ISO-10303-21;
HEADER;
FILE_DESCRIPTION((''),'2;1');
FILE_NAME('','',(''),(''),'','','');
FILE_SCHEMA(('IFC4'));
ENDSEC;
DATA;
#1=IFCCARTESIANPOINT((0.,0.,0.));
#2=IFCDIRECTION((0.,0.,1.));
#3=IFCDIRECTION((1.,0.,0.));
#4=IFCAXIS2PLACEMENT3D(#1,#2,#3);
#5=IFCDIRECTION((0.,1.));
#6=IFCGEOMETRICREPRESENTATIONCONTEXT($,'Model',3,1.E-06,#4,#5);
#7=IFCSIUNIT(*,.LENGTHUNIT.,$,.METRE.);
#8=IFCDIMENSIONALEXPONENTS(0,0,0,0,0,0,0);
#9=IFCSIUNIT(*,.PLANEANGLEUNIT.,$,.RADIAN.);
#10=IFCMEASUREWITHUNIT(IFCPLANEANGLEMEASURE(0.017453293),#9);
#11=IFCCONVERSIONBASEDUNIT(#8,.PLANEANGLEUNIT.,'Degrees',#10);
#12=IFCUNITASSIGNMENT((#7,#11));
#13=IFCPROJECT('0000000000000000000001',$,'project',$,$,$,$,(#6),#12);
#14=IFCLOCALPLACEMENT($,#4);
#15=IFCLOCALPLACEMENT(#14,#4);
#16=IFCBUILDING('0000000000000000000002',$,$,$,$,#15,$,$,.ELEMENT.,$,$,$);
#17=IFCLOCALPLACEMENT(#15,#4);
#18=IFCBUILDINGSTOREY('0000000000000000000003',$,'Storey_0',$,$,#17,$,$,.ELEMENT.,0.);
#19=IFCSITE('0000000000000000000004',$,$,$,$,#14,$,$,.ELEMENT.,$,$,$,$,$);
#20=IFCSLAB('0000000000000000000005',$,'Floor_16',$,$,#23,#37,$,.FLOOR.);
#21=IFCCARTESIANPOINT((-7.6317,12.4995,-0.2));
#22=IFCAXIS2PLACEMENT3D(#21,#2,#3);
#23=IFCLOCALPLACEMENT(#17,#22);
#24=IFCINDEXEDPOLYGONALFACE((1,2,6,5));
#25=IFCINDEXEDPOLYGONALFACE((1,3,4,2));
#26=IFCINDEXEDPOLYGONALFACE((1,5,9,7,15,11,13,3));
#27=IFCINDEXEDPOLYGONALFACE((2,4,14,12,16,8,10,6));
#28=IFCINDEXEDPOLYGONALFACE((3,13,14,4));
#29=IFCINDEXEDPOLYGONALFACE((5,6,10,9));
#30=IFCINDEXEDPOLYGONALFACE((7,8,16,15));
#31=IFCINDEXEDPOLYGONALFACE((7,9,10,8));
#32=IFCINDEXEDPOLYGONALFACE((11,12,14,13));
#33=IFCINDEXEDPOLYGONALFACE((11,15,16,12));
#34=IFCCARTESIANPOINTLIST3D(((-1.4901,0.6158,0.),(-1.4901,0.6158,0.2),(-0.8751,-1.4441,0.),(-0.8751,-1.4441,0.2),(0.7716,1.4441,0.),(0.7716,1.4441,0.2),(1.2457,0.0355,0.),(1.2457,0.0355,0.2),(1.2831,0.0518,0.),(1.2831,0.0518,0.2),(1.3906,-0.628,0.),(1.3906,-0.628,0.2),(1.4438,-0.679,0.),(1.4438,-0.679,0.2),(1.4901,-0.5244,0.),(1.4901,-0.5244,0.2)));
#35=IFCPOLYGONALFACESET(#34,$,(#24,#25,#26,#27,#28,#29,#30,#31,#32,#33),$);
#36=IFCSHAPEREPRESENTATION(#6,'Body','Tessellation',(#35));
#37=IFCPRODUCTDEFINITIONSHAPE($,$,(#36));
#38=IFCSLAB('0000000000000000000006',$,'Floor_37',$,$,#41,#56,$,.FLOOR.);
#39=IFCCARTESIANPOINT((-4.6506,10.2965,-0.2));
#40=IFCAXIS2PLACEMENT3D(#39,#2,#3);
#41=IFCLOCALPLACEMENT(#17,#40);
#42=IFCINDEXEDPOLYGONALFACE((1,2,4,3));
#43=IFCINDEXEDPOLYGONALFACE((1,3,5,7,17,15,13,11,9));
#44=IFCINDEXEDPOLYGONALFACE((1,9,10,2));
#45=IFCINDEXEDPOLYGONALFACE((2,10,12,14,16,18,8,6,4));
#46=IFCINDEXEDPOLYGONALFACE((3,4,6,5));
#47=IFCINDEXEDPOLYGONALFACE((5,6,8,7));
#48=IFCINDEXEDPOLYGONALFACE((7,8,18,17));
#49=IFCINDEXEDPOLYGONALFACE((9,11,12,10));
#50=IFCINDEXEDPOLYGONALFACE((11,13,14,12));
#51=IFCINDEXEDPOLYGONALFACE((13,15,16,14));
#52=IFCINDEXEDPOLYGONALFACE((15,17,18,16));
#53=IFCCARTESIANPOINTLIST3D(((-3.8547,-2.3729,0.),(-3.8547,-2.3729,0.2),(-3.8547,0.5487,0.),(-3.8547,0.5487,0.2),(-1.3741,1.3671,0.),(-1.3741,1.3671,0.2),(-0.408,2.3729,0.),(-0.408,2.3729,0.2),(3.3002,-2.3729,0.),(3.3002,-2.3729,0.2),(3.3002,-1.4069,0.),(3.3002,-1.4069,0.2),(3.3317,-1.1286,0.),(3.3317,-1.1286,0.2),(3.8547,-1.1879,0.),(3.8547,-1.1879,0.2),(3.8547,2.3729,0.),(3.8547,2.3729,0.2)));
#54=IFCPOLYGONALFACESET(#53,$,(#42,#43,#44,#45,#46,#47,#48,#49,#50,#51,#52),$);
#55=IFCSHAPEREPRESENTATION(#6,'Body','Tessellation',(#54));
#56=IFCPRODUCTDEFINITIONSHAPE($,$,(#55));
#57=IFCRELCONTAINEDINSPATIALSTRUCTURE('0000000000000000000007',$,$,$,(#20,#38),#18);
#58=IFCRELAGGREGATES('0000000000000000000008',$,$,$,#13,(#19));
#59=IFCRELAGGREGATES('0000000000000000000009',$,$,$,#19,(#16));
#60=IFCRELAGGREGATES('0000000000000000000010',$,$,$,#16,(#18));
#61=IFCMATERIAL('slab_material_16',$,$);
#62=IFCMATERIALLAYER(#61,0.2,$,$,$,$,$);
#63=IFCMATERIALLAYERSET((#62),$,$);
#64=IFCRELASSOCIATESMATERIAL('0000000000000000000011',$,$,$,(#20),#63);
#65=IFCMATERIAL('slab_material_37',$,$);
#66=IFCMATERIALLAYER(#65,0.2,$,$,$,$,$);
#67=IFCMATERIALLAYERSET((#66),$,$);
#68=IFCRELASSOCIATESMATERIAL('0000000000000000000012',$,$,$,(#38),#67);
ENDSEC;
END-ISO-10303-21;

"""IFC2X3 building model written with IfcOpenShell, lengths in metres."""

from ifc_helpers import new_model, entity, si_unit, converted_unit, direction, frame, origin_with_axes, place, context, project, spatial, polyline, outline, extrude, material, layer, layer_set, layer_usage, element, save


model = new_model("IFC2X3")

# Units and contexts
model_context = context("Model", 3, precision=1e-06, world=origin_with_axes(), true_north=direction((0.0, 1.0)))
ifc_project = project(units=[si_unit("LENGTHUNIT", "METRE"), converted_unit("PLANEANGLEUNIT", "Degrees", entity("IfcPlaneAngleMeasure", 0.017453293), si_unit("PLANEANGLEUNIT", "RADIAN"), dimensions=[0, 0, 0, 0, 0, 0, 0])], contexts=[model_context])

# Site, building, storey
site_placement = place(None, origin_with_axes())
site = spatial("IfcSite", under=ifc_project, at=site_placement, CompositionType="ELEMENT")
building_placement = place(site_placement, origin_with_axes())
building = spatial("IfcBuilding", under=site, at=building_placement, CompositionType="ELEMENT")
storey_placement = place(building_placement, origin_with_axes())
storey = spatial("IfcBuildingStorey", under=building, at=storey_placement, Name="Storey_0", CompositionType="ELEMENT", Elevation=0.0)

# Slabs
ifc_material_1 = material(Name="slab_material_16")
ifc_layer_1 = layer(ifc_material_1, 0.2)
ifc_layer_set_1 = layer_set([ifc_layer_1])
ifc_layer_usage_1 = layer_usage(ifc_layer_set_1, "AXIS3", "POSITIVE", 0.0)
slab_1_placement = place(storey_placement, frame((-7.6317, 12.4995, -0.2), z_axis=(0.0, 0.0, 1.0), x_axis=(1.0, 0.0, 0.0)))
element("IfcSlab", 1, at=slab_1_placement, inside=storey, material=ifc_layer_usage_1, Name="Floor_16", PredefinedType="FLOOR", context=model_context, shape_type="SweptSolid", body=[
    extrude(outline(polyline([(1.2831, 0.0518), (1.2457, 0.0355), (1.4901, -0.5244), (1.3906, -0.628), (1.4438, -0.679), (-0.8751, -1.4441), (-1.4901, 0.6158), (0.7716, 1.4441), (1.2831, 0.0518)])), origin_with_axes(), (0.0, 0.0, 1.0), 0.2),
])
ifc_material_2 = material(Name="slab_material_37")
ifc_layer_2 = layer(ifc_material_2, 0.2)
ifc_layer_set_2 = layer_set([ifc_layer_2])
ifc_layer_usage_2 = layer_usage(ifc_layer_set_2, "AXIS3", "POSITIVE", 0.0)
slab_2_placement = place(storey_placement, frame((-4.6506, 10.2965, -0.2), z_axis=(0.0, 0.0, 1.0), x_axis=(1.0, 0.0, 0.0)))
element("IfcSlab", 2, at=slab_2_placement, inside=storey, material=ifc_layer_usage_2, Name="Floor_37", PredefinedType="FLOOR", context=model_context, shape_type="SweptSolid", body=[
    extrude(outline(polyline([(3.8547, 2.3729), (3.8547, -1.1879), (3.3317, -1.1286), (3.3002, -1.4069), (3.3002, -2.3729), (-3.8547, -2.3729), (-3.8547, 0.5487), (-1.3741, 1.3671), (-0.408, 2.3729), (3.8547, 2.3729)])), origin_with_axes(), (0.0, 0.0, 1.0), 0.2),
])

save(model, "model.ifc")
